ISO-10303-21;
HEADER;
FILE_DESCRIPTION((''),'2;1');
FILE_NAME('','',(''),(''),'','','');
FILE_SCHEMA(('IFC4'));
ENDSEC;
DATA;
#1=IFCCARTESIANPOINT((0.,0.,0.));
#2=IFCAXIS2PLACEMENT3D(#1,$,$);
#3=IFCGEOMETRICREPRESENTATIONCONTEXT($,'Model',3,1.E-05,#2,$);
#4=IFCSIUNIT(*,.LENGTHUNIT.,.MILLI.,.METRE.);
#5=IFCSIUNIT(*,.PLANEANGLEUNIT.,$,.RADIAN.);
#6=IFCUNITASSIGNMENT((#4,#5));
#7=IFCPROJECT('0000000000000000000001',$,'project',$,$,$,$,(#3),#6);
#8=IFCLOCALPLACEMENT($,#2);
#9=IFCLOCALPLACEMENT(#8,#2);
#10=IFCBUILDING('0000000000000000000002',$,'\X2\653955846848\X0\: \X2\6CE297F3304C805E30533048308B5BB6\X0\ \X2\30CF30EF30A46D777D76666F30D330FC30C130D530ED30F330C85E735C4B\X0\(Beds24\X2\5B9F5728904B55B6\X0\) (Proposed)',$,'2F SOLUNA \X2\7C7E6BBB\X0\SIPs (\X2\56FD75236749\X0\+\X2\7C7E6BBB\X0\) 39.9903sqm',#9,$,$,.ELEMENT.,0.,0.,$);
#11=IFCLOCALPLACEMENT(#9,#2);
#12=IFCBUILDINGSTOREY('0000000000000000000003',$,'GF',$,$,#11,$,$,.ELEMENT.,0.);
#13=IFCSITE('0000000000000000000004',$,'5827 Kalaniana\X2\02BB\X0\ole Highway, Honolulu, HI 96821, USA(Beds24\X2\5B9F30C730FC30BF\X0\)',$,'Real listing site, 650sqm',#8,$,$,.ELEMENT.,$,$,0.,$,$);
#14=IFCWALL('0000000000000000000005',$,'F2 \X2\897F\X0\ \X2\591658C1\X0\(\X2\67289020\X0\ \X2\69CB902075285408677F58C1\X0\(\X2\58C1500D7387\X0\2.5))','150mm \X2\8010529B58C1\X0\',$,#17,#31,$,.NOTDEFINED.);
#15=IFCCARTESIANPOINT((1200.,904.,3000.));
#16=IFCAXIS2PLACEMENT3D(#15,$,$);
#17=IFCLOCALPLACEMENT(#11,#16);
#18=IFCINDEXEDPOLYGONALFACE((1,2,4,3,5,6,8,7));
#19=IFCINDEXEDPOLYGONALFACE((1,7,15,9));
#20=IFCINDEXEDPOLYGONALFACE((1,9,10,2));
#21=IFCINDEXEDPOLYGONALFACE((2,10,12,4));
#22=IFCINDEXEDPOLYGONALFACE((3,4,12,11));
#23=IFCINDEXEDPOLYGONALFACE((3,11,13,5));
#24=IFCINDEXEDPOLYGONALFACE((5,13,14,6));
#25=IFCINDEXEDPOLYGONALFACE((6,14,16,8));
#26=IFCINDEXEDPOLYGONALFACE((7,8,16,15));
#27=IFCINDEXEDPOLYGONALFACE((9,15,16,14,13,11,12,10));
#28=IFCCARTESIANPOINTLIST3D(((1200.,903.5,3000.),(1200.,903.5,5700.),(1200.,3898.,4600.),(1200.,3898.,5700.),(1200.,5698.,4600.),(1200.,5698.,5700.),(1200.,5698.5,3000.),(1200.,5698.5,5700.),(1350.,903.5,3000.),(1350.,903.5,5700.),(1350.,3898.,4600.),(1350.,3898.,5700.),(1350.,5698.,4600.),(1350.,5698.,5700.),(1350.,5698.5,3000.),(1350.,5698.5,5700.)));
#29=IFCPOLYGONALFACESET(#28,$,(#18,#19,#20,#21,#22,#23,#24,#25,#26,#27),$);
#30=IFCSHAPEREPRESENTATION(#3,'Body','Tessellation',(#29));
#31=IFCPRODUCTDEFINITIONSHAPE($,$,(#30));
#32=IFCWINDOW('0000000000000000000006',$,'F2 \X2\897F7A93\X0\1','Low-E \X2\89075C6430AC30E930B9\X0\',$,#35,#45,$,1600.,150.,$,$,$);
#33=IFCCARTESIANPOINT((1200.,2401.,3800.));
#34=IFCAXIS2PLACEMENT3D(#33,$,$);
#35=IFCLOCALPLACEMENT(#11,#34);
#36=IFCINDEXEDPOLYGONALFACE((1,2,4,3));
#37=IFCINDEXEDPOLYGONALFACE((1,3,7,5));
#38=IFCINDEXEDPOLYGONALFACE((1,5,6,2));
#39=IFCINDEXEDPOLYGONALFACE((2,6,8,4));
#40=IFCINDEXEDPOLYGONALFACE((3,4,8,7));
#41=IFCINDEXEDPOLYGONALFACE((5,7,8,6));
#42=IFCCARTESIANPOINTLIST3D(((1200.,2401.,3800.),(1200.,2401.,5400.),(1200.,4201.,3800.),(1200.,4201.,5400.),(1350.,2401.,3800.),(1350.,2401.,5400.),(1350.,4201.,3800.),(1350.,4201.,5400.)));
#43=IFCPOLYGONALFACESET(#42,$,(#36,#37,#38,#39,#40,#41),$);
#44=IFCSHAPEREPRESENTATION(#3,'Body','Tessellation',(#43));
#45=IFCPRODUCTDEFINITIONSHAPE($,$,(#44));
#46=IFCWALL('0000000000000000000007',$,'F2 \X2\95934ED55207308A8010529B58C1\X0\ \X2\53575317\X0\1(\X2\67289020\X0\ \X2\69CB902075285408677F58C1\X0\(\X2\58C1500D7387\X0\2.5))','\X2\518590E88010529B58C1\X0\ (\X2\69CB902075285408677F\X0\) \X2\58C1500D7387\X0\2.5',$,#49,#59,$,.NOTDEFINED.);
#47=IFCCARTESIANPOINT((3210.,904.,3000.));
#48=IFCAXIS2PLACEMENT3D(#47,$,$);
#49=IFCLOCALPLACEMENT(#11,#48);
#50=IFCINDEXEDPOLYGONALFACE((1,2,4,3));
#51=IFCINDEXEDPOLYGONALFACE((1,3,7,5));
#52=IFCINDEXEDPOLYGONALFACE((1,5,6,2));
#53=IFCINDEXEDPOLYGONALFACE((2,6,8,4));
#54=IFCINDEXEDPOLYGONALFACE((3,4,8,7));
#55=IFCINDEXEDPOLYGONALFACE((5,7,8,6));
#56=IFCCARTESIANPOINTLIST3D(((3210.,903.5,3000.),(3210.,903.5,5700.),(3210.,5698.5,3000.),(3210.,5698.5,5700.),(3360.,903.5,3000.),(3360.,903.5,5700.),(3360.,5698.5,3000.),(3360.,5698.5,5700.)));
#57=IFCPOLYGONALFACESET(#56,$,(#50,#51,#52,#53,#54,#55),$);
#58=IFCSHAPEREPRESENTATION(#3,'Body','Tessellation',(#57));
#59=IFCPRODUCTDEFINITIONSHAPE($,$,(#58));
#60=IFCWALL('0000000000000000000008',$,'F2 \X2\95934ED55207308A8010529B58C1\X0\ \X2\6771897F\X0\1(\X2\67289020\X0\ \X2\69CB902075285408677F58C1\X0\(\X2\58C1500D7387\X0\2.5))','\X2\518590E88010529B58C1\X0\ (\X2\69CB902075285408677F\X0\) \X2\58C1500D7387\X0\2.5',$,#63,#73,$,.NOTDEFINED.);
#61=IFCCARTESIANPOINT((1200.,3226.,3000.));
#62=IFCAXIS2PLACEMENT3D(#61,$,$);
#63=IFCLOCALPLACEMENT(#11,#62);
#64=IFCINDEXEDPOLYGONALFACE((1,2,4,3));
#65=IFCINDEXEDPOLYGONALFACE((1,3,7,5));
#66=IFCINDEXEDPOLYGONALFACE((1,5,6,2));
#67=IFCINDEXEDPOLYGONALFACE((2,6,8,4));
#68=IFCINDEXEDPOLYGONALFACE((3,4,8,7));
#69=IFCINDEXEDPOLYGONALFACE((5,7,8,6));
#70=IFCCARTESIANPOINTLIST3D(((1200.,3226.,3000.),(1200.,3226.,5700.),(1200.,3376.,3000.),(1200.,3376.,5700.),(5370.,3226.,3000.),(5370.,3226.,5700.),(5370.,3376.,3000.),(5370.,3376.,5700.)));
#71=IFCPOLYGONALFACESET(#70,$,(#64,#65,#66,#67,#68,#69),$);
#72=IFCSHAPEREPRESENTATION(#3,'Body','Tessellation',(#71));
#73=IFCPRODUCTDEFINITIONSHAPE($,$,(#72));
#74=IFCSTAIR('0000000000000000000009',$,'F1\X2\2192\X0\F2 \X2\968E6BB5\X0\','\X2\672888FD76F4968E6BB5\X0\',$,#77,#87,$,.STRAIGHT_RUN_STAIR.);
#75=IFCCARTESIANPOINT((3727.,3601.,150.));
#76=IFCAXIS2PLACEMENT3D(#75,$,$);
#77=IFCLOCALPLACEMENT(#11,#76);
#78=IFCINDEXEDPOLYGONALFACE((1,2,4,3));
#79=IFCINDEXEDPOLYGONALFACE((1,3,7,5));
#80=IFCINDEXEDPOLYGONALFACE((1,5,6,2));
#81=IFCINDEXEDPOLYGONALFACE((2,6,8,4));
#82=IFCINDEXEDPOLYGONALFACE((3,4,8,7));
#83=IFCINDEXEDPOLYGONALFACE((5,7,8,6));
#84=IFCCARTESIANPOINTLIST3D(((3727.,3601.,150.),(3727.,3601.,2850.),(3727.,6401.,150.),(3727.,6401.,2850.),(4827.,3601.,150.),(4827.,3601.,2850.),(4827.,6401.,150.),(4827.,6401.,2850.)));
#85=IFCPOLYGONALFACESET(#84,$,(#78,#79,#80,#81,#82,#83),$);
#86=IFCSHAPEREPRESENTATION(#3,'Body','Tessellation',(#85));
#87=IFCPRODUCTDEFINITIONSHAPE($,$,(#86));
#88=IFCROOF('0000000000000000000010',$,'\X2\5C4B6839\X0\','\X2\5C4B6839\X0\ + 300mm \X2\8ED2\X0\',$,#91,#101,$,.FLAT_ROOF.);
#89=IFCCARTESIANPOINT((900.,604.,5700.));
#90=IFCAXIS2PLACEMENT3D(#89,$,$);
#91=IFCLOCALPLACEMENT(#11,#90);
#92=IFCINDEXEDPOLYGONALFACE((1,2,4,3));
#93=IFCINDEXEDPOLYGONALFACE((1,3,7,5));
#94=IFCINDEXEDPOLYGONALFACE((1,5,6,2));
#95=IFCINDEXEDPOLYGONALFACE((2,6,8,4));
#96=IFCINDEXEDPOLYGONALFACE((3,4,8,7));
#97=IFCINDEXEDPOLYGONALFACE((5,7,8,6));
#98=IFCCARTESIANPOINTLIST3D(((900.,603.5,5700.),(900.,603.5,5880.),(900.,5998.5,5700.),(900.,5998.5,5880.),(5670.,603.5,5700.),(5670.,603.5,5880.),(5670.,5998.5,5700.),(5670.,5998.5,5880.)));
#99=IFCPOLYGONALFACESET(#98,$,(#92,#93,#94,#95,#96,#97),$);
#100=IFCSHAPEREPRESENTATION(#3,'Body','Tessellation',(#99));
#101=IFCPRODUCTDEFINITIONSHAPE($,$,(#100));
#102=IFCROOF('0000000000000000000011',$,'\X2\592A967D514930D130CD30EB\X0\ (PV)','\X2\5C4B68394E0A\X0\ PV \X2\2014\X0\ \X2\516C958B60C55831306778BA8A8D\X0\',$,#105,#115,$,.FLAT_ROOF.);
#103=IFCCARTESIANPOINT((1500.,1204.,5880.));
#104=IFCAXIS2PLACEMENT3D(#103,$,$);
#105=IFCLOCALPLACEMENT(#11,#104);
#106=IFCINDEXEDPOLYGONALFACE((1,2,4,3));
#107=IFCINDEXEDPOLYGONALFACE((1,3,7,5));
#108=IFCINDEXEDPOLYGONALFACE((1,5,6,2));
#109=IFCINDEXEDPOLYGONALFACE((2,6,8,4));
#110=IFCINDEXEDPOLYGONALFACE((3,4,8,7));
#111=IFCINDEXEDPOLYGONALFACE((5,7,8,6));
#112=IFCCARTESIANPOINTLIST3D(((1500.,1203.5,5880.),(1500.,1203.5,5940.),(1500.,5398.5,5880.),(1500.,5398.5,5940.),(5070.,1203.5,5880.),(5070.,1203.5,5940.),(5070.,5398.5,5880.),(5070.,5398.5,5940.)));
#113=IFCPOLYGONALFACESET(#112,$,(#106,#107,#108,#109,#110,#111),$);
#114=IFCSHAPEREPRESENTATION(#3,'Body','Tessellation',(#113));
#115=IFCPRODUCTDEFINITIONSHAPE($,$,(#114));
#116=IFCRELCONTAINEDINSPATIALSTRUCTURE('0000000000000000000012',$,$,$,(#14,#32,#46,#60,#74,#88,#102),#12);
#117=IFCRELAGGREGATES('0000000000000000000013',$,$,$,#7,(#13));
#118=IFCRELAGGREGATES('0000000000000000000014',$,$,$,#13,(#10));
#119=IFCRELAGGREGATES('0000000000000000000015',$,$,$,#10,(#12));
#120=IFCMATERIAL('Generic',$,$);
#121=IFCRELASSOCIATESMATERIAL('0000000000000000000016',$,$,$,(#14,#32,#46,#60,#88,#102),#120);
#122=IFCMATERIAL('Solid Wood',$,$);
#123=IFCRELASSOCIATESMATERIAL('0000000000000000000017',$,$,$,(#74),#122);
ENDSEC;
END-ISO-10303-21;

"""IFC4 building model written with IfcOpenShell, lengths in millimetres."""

from ifc_helpers import new_model, si_unit, frame, frame_2d, origin, place, context, project, spatial, rectangle, extrude, material, element, fill, save


model = new_model("IFC4")

# Units and contexts
model_context = context("Model", 3, precision=1e-05, world=origin())
ifc_project = project(units=[si_unit("LENGTHUNIT", "METRE", prefix="MILLI"), si_unit("PLANEANGLEUNIT", "RADIAN")], contexts=[model_context])

# Site, building, storey
site_placement = place(None, origin())
site = spatial("IfcSite", under=ifc_project, at=site_placement, Name="5827 Kalanianaʻole Highway, Honolulu, HI 96821, USA(Beds24実データ)", ObjectType="Real listing site, 650sqm", CompositionType="ELEMENT", RefElevation=0.0)
building_placement = place(site_placement, origin())
building = spatial("IfcBuilding", under=site, at=building_placement, Name="改善案: 波音が聞こえる家 ハワイ海絶景ビーチフロント平屋(Beds24実在運営) (Proposed)", ObjectType="2F SOLUNA 籾殻SIPs (国産杉+籾殻) 39.9903sqm", CompositionType="ELEMENT", ElevationOfRefHeight=0.0, ElevationOfTerrain=0.0)
storey_placement = place(building_placement, origin())
storey = spatial("IfcBuildingStorey", under=building, at=storey_placement, Name="GF", CompositionType="ELEMENT", Elevation=0.0)

# Shared definitions
ifc_material_1 = material(Name="Generic")

# Shared definitions
ifc_material_2 = material(Name="Solid Wood")

# Wall, opening, window
wall_1_placement = place(storey_placement, frame((1200.0, 904.0, 3000.0)))
wall_1 = element("IfcWall", 1, at=wall_1_placement, inside=storey, material=ifc_material_1, Name="F2 西 外壁(木造 構造用合板壁(壁倍率2.5))", Description="150mm 耐力壁", PredefinedType="NOTDEFINED", context=model_context, shape_type="SweptSolid", body=[
    extrude(rectangle(XDim=150.0, YDim=4795.0, at=frame_2d((75.0, 2397.0))), frame((1200.0, 904.0, 3000.0)), (0.0, 0.0, 1.0), 2700.0),
])
opening_1_placement = place(storey_placement, frame((1200.0, 2401.0, 3800.0)))
opening_1 = element("IfcOpeningElement", 2, at=opening_1_placement, cuts=wall_1, PredefinedType="NOTDEFINED", context=model_context, shape_type="SweptSolid", body=[
    extrude(rectangle(XDim=150.0, YDim=1800.0, at=frame_2d((75.0, 900.0))), frame((1200.0, 2401.0, 3800.0)), (0.0, 0.0, 1.0), 1600.0),
])
window_1_placement = place(storey_placement, frame((1200.0, 2401.0, 3800.0)))
window_1 = element("IfcWindow", 3, at=window_1_placement, inside=storey, material=ifc_material_1, Name="F2 西窓1", Description="Low-E 複層ガラス", OverallHeight=1600.0, OverallWidth=150.0, context=model_context, shape_type="SweptSolid", body=[
    extrude(rectangle(XDim=150.0, YDim=1800.0, at=frame_2d((75.0, 900.0))), frame((1200.0, 2401.0, 3800.0)), (0.0, 0.0, 1.0), 1600.0),
])
fill(opening_1, window_1)

# Walls
wall_2_placement = place(storey_placement, frame((3210.0, 904.0, 3000.0)))
element("IfcWall", 4, at=wall_2_placement, inside=storey, material=ifc_material_1, Name="F2 間仕切り耐力壁 南北1(木造 構造用合板壁(壁倍率2.5))", Description="内部耐力壁 (構造用合板) 壁倍率2.5", PredefinedType="NOTDEFINED", context=model_context, shape_type="SweptSolid", body=[
    extrude(rectangle(XDim=150.0, YDim=4795.0, at=frame_2d((75.0, 2397.0))), frame((3210.0, 904.0, 3000.0)), (0.0, 0.0, 1.0), 2700.0),
])
wall_3_placement = place(storey_placement, frame((1200.0, 3226.0, 3000.0)))
element("IfcWall", 5, at=wall_3_placement, inside=storey, material=ifc_material_1, Name="F2 間仕切り耐力壁 東西1(木造 構造用合板壁(壁倍率2.5))", Description="内部耐力壁 (構造用合板) 壁倍率2.5", PredefinedType="NOTDEFINED", context=model_context, shape_type="SweptSolid", body=[
    extrude(rectangle(XDim=4170.0, YDim=150.0, at=frame_2d((2085.0, 75.0))), frame((1200.0, 3226.0, 3000.0)), (0.0, 0.0, 1.0), 2700.0),
])

# Stair
stair_placement = place(storey_placement, frame((3727.0, 3601.0, 150.0)))
element("IfcStair", 6, at=stair_placement, inside=storey, material=ifc_material_2, Name="F1→F2 階段", Description="木製直階段", PredefinedType="STRAIGHT_RUN_STAIR", context=model_context, shape_type="SweptSolid", body=[
    extrude(rectangle(XDim=1100.0, YDim=2800.0, at=frame_2d((550.0, 1400.0))), frame((3727.0, 3601.0, 150.0)), (0.0, 0.0, 1.0), 2700.0),
])

# Roofs
roof_1_placement = place(storey_placement, frame((900.0, 604.0, 5700.0)))
element("IfcRoof", 7, at=roof_1_placement, inside=storey, material=ifc_material_1, Name="屋根", Description="屋根 + 300mm 軒", PredefinedType="FLAT_ROOF", context=model_context, shape_type="SweptSolid", body=[
    extrude(rectangle(XDim=4770.0, YDim=5395.0, at=frame_2d((2385.0, 2697.0))), frame((900.0, 604.0, 5700.0)), (0.0, 0.0, 1.0), 180.0),
])
roof_2_placement = place(storey_placement, frame((1500.0, 1204.0, 5880.0)))
element("IfcRoof", 8, at=roof_2_placement, inside=storey, material=ifc_material_1, Name="太陽光パネル (PV)", Description="屋根上 PV — 公開情報で確認", PredefinedType="FLAT_ROOF", context=model_context, shape_type="SweptSolid", body=[
    extrude(rectangle(XDim=3570.0, YDim=4195.0, at=frame_2d((1785.0, 2097.0))), frame((1500.0, 1204.0, 5880.0)), (0.0, 0.0, 1.0), 60.0),
])

save(model, "model.ifc")
